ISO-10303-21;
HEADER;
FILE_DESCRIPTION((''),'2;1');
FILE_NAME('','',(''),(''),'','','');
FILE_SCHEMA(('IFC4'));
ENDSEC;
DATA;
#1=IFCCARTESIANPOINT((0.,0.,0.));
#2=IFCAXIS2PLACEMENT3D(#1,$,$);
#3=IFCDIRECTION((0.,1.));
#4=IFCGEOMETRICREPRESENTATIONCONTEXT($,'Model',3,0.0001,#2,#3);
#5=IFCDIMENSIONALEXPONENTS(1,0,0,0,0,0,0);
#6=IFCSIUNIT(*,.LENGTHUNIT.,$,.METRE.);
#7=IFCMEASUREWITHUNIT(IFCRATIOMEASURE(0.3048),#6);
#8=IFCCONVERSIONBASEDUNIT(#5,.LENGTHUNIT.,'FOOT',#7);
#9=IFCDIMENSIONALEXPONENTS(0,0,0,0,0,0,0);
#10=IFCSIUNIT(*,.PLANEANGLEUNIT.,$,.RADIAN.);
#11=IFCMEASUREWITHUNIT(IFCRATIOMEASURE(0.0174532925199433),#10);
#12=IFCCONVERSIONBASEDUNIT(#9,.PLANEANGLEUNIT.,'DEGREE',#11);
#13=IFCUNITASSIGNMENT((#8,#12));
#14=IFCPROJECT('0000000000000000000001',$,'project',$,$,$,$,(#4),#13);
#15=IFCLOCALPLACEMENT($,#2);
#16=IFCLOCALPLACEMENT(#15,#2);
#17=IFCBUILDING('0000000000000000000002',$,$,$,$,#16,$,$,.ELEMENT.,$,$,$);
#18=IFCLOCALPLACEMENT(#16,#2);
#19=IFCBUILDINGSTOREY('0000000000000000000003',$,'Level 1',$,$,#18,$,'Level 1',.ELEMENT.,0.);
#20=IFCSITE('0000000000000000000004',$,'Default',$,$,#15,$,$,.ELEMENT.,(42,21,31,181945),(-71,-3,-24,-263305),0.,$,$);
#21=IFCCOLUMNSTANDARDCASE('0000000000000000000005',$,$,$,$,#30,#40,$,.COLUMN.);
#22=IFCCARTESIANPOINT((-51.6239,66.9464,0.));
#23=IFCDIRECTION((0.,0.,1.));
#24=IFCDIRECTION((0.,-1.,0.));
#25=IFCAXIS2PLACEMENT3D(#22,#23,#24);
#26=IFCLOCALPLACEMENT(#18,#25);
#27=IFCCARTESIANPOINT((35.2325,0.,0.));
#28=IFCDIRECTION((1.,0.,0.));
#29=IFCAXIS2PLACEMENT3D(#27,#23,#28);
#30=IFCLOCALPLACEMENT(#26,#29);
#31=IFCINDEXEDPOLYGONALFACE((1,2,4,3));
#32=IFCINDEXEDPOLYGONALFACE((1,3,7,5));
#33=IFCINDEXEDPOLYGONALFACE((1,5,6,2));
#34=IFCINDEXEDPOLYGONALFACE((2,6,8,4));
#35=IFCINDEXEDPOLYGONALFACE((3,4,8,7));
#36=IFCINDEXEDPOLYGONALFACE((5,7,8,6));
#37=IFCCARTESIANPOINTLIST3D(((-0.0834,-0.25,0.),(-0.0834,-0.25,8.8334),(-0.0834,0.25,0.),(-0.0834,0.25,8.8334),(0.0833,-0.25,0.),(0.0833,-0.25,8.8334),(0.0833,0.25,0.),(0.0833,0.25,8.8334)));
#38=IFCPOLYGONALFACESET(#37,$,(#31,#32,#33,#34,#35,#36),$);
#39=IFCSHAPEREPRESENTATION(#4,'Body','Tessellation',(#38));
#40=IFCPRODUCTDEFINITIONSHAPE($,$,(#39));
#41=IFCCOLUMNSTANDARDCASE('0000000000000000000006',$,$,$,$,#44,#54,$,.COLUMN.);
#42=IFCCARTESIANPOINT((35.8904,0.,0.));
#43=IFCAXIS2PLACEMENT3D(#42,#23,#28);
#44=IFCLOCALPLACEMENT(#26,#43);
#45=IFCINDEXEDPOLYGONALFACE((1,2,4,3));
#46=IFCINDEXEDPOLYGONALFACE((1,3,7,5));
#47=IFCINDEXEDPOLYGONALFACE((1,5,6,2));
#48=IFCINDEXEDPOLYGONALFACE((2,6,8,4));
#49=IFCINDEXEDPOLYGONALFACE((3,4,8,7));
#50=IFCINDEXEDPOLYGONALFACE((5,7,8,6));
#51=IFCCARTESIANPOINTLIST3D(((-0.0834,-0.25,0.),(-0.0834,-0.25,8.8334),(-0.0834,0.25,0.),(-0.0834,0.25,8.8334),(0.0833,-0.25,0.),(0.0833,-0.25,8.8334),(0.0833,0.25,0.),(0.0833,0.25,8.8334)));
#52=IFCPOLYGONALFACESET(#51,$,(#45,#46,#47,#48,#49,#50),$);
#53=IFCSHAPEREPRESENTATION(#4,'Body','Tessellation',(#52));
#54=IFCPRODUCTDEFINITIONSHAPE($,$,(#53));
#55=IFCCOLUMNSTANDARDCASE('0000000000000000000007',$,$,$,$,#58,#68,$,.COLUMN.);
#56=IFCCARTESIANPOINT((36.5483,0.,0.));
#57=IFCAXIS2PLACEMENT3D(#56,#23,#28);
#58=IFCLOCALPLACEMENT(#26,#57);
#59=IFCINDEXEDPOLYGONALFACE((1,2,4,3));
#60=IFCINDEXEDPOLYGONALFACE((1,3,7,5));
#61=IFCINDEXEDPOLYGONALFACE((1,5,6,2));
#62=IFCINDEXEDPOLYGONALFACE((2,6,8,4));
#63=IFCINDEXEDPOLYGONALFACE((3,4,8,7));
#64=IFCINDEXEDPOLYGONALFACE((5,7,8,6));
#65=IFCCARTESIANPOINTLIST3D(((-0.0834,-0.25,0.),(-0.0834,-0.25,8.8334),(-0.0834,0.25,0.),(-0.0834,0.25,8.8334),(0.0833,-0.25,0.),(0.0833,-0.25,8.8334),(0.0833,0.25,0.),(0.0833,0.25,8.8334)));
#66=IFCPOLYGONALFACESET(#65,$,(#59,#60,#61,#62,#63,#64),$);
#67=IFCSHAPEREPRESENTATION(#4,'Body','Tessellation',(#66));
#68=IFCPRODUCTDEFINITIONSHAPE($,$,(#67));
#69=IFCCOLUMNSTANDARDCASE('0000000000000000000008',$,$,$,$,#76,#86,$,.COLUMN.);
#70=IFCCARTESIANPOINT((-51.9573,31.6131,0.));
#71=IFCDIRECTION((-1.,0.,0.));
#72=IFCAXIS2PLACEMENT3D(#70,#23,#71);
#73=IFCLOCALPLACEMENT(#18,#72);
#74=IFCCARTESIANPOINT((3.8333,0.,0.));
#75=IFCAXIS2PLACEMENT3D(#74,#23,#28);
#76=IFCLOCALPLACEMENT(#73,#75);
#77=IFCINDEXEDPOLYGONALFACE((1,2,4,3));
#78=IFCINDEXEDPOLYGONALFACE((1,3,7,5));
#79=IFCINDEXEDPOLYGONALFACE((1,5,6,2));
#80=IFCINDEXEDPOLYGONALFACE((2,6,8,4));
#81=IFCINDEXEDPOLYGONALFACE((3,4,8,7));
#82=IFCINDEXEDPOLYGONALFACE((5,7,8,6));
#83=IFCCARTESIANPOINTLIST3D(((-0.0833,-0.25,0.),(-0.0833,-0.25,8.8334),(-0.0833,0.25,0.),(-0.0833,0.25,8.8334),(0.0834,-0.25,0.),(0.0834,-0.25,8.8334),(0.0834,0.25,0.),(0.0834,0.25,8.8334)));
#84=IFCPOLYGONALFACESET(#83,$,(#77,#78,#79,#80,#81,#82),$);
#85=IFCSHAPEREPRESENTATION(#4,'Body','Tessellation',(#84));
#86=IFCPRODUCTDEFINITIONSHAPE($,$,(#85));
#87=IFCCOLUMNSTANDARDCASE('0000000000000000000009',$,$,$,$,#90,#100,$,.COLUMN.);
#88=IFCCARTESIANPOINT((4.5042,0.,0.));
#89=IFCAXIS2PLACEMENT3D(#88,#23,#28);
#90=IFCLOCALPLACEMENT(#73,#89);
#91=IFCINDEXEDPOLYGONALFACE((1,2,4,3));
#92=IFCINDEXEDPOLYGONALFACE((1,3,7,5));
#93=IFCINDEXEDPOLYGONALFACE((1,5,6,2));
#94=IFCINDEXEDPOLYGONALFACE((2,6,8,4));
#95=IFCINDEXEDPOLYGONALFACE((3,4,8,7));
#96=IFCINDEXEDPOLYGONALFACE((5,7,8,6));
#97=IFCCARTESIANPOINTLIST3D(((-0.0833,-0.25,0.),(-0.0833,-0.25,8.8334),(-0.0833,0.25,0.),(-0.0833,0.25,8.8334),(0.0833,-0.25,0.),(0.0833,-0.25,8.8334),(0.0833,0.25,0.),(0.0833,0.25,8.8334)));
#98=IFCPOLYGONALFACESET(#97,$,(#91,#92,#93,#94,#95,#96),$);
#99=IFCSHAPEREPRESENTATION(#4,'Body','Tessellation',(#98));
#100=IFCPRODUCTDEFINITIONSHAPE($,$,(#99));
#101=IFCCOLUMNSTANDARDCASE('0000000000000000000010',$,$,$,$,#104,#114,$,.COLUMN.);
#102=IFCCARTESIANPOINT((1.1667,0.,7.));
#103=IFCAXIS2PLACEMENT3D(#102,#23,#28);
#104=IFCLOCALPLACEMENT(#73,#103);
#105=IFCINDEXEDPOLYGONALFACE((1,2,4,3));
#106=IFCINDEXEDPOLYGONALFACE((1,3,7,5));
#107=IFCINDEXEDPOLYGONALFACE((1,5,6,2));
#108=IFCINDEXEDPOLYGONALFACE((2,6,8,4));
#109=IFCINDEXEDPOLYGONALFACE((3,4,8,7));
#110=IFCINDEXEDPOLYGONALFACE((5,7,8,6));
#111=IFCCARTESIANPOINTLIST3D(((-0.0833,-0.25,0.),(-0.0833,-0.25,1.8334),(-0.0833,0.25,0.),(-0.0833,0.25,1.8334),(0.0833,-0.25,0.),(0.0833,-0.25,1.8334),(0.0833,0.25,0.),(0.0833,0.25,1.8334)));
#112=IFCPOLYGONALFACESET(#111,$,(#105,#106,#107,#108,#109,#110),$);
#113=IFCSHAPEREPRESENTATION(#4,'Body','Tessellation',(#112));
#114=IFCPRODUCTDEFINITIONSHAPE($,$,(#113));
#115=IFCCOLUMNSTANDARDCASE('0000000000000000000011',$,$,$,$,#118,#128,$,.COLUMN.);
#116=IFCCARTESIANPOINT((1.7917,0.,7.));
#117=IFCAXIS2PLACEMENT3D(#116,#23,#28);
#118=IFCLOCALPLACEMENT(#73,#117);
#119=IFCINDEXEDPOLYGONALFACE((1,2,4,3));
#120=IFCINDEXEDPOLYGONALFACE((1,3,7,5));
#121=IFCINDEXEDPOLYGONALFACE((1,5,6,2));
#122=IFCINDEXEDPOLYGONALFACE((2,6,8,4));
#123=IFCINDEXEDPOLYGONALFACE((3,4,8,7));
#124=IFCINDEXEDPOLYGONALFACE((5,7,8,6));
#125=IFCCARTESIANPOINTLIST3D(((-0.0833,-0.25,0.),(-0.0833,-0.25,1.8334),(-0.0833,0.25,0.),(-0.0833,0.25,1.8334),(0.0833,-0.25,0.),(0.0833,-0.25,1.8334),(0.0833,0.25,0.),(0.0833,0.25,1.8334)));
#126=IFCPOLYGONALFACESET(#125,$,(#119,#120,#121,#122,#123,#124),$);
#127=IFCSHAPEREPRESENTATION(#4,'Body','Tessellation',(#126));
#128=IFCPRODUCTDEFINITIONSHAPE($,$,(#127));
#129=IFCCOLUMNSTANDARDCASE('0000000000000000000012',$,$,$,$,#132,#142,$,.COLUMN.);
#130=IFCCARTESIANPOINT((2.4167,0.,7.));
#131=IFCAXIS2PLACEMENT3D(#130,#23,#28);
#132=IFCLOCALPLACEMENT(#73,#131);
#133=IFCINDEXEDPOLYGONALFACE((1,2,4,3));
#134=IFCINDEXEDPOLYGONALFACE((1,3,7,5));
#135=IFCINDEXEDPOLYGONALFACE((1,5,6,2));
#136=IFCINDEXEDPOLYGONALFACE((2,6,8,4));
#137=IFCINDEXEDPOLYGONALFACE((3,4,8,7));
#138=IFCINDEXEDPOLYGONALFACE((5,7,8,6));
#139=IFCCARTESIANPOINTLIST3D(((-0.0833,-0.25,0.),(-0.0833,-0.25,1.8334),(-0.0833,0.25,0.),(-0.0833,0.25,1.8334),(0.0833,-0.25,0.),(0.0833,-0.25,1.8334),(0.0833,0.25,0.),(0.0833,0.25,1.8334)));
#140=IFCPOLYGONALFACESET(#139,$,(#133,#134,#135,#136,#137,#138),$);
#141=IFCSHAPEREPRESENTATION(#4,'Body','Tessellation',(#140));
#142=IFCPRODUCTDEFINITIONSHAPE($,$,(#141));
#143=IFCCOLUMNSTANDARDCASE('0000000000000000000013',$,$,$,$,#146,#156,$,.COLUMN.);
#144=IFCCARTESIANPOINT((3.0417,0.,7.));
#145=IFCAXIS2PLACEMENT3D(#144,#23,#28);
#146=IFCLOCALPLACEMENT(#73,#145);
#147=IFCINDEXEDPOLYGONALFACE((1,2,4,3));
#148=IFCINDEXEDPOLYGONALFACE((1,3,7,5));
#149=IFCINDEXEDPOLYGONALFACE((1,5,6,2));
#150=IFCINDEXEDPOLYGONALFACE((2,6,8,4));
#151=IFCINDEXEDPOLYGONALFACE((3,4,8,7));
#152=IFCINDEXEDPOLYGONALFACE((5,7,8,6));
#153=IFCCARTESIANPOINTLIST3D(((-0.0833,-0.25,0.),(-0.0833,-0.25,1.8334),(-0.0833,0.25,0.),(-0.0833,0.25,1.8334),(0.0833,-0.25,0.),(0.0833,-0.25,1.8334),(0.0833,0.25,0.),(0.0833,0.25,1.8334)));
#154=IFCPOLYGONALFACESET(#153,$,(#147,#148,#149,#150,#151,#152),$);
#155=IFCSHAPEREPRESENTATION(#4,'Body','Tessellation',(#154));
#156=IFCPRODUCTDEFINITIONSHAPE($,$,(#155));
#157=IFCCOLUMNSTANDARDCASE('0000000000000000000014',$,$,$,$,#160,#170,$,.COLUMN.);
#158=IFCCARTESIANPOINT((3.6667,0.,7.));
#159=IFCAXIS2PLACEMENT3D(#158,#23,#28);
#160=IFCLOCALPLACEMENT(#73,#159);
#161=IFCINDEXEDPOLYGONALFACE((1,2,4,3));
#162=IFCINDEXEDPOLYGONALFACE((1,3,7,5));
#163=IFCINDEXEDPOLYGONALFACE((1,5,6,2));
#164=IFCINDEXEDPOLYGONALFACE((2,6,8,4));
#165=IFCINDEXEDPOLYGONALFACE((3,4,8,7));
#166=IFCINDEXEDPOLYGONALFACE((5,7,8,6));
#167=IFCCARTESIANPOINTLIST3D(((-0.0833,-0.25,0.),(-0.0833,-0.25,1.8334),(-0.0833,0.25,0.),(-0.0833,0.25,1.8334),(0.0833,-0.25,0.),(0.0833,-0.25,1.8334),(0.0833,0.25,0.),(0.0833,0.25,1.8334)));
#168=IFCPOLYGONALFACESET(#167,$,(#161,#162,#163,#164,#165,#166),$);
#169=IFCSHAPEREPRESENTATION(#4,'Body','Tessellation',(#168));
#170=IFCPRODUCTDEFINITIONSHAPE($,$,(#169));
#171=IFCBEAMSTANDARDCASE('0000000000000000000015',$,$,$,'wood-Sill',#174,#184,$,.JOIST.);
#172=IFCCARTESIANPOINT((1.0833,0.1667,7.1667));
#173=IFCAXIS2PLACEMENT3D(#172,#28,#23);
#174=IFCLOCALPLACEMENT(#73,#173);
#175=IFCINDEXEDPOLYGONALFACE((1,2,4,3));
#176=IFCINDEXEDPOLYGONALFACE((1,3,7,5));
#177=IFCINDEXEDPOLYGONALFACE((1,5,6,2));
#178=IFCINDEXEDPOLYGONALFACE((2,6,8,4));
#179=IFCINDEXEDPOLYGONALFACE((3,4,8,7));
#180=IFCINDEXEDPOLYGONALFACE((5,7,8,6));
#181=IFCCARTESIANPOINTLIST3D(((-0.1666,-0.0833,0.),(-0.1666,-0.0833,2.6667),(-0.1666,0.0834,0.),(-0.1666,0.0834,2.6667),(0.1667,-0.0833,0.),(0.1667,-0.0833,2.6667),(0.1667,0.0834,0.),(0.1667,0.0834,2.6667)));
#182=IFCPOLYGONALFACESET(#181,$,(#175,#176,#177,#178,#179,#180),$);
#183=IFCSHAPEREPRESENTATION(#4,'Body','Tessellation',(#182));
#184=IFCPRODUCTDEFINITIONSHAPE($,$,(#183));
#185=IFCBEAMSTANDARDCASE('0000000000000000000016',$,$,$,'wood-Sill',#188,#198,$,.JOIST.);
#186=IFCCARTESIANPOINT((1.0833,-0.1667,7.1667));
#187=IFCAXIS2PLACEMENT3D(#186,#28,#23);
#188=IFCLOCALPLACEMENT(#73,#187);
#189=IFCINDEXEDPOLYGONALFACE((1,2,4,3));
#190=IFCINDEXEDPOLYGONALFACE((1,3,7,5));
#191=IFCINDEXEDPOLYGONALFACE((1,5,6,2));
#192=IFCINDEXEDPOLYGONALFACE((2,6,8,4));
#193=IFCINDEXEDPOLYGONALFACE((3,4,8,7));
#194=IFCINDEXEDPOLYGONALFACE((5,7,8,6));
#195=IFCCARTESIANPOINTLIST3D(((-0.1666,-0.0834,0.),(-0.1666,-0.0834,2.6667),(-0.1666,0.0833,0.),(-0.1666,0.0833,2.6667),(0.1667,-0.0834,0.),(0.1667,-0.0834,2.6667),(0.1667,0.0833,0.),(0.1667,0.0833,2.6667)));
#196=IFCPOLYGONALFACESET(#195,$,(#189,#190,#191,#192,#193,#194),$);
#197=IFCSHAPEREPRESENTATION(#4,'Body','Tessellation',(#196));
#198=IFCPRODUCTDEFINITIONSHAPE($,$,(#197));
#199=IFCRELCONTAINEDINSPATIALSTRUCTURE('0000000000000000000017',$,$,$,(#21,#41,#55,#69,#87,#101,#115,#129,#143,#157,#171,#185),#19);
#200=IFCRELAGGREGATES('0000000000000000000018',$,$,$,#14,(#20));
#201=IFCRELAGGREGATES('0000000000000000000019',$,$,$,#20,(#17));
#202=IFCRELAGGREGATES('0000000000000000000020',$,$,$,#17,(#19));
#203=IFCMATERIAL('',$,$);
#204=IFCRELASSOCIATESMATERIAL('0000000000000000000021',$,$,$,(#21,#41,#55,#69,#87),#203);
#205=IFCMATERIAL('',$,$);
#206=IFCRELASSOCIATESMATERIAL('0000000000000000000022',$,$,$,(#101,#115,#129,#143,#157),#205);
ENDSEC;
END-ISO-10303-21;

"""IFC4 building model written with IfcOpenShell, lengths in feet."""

from ifc_helpers import new_model, entity, si_unit, converted_unit, direction, frame, origin, origin_with_axes, place, context, project, spatial, rectangle, extrude, material, element, save


model = new_model("IFC4")

# Units and contexts
model_context = context("Model", 3, precision=0.0001, world=origin(), true_north=direction((0.0, 1.0)))
ifc_project = project(units=[converted_unit("LENGTHUNIT", "FOOT", entity("IfcRatioMeasure", 0.3048), si_unit("LENGTHUNIT", "METRE"), dimensions=[1, 0, 0, 0, 0, 0, 0]), converted_unit("PLANEANGLEUNIT", "DEGREE", entity("IfcRatioMeasure", 0.0174532925199433), si_unit("PLANEANGLEUNIT", "RADIAN"), dimensions=[0, 0, 0, 0, 0, 0, 0])], contexts=[model_context])

# Site, building, storey
site_placement = place(None, origin())
site = spatial("IfcSite", under=ifc_project, at=site_placement, Name="Default", CompositionType="ELEMENT", RefLatitude=(42, 21, 31, 181945), RefLongitude=(-71, -3, -24, -263305), RefElevation=0.0)
building_placement = place(site_placement, origin())
building = spatial("IfcBuilding", under=site, at=building_placement, CompositionType="ELEMENT")
storey_placement = place(building_placement, origin())
storey = spatial("IfcBuildingStorey", under=building, at=storey_placement, Name="Level 1", LongName="Level 1", CompositionType="ELEMENT", Elevation=0.0)

# Columns
ifc_material_1 = material(Name="")
placement_1 = place(storey_placement, frame((-51.6239, 66.9464, 0.0), z_axis=(0.0, 0.0, 1.0), x_axis=(0.0, -1.0, 0.0)))
for number, where, z_axis, x_axis in (
    (1, (35.2325, 0.0, 0.0), (0.0, 0.0, 1.0), (1.0, 0.0, 0.0)),
    (2, (35.8904, 0.0, 0.0), (0.0, 0.0, 1.0), (1.0, 0.0, 0.0)),
    (3, (36.5483, 0.0, 0.0), (0.0, 0.0, 1.0), (1.0, 0.0, 0.0)),
):
    element("IfcColumnStandardCase", number, at=place(placement_1, frame(where, z_axis=z_axis, x_axis=x_axis)), inside=storey, material=ifc_material_1, PredefinedType="COLUMN", context=model_context, shape_type="SweptSolid", body=[
        extrude(rectangle(XDim=0.1667, YDim=0.5), origin(), (0.0, 0.0, 1.0), 8.8334),
    ])
placement_2 = place(storey_placement, frame((-51.9573, 31.6131, 0.0), z_axis=(0.0, 0.0, 1.0), x_axis=(-1.0, 0.0, 0.0)))
for number, where, z_axis, x_axis in (
    (4, (3.8333, 0.0, 0.0), (0.0, 0.0, 1.0), (1.0, 0.0, 0.0)),
    (5, (4.5042, 0.0, 0.0), (0.0, 0.0, 1.0), (1.0, 0.0, 0.0)),
):
    element("IfcColumnStandardCase", number, at=place(placement_2, frame(where, z_axis=z_axis, x_axis=x_axis)), inside=storey, material=ifc_material_1, PredefinedType="COLUMN", context=model_context, shape_type="SweptSolid", body=[
        extrude(rectangle(XDim=0.1667, YDim=0.5), origin(), (0.0, 0.0, 1.0), 8.8334),
    ])
ifc_material_2 = material(Name="")
for number, where, z_axis, x_axis in (
    (6, (1.1667, 0.0, 7.0), (0.0, 0.0, 1.0), (1.0, 0.0, 0.0)),
    (7, (1.7917, 0.0, 7.0), (0.0, 0.0, 1.0), (1.0, 0.0, 0.0)),
    (8, (2.4167, 0.0, 7.0), (0.0, 0.0, 1.0), (1.0, 0.0, 0.0)),
    (9, (3.0417, 0.0, 7.0), (0.0, 0.0, 1.0), (1.0, 0.0, 0.0)),
    (10, (3.6667, 0.0, 7.0), (0.0, 0.0, 1.0), (1.0, 0.0, 0.0)),
):
    element("IfcColumnStandardCase", number, at=place(placement_2, frame(where, z_axis=z_axis, x_axis=x_axis)), inside=storey, material=ifc_material_2, PredefinedType="COLUMN", context=model_context, shape_type="SweptSolid", body=[
        extrude(rectangle(XDim=0.1667, YDim=0.5), origin(), (0.0, 0.0, 1.0), 1.8334),
    ])

# Beams
for number, where, z_axis, x_axis in (
    (11, (1.0833, 0.1667, 7.1667), (1.0, 0.0, 0.0), (0.0, 0.0, 1.0)),
    (12, (1.0833, -0.1667, 7.1667), (1.0, 0.0, 0.0), (0.0, 0.0, 1.0)),
):
    element("IfcBeamStandardCase", number, at=place(placement_2, frame(where, z_axis=z_axis, x_axis=x_axis)), inside=storey, ObjectType="wood-Sill", PredefinedType="JOIST", context=model_context, shape_type="SweptSolid", body=[
        extrude(rectangle(XDim=0.3333, YDim=0.1667), origin_with_axes(), (0.0, 0.0, 1.0), 2.6667),
    ])

save(model, "model.ifc")
